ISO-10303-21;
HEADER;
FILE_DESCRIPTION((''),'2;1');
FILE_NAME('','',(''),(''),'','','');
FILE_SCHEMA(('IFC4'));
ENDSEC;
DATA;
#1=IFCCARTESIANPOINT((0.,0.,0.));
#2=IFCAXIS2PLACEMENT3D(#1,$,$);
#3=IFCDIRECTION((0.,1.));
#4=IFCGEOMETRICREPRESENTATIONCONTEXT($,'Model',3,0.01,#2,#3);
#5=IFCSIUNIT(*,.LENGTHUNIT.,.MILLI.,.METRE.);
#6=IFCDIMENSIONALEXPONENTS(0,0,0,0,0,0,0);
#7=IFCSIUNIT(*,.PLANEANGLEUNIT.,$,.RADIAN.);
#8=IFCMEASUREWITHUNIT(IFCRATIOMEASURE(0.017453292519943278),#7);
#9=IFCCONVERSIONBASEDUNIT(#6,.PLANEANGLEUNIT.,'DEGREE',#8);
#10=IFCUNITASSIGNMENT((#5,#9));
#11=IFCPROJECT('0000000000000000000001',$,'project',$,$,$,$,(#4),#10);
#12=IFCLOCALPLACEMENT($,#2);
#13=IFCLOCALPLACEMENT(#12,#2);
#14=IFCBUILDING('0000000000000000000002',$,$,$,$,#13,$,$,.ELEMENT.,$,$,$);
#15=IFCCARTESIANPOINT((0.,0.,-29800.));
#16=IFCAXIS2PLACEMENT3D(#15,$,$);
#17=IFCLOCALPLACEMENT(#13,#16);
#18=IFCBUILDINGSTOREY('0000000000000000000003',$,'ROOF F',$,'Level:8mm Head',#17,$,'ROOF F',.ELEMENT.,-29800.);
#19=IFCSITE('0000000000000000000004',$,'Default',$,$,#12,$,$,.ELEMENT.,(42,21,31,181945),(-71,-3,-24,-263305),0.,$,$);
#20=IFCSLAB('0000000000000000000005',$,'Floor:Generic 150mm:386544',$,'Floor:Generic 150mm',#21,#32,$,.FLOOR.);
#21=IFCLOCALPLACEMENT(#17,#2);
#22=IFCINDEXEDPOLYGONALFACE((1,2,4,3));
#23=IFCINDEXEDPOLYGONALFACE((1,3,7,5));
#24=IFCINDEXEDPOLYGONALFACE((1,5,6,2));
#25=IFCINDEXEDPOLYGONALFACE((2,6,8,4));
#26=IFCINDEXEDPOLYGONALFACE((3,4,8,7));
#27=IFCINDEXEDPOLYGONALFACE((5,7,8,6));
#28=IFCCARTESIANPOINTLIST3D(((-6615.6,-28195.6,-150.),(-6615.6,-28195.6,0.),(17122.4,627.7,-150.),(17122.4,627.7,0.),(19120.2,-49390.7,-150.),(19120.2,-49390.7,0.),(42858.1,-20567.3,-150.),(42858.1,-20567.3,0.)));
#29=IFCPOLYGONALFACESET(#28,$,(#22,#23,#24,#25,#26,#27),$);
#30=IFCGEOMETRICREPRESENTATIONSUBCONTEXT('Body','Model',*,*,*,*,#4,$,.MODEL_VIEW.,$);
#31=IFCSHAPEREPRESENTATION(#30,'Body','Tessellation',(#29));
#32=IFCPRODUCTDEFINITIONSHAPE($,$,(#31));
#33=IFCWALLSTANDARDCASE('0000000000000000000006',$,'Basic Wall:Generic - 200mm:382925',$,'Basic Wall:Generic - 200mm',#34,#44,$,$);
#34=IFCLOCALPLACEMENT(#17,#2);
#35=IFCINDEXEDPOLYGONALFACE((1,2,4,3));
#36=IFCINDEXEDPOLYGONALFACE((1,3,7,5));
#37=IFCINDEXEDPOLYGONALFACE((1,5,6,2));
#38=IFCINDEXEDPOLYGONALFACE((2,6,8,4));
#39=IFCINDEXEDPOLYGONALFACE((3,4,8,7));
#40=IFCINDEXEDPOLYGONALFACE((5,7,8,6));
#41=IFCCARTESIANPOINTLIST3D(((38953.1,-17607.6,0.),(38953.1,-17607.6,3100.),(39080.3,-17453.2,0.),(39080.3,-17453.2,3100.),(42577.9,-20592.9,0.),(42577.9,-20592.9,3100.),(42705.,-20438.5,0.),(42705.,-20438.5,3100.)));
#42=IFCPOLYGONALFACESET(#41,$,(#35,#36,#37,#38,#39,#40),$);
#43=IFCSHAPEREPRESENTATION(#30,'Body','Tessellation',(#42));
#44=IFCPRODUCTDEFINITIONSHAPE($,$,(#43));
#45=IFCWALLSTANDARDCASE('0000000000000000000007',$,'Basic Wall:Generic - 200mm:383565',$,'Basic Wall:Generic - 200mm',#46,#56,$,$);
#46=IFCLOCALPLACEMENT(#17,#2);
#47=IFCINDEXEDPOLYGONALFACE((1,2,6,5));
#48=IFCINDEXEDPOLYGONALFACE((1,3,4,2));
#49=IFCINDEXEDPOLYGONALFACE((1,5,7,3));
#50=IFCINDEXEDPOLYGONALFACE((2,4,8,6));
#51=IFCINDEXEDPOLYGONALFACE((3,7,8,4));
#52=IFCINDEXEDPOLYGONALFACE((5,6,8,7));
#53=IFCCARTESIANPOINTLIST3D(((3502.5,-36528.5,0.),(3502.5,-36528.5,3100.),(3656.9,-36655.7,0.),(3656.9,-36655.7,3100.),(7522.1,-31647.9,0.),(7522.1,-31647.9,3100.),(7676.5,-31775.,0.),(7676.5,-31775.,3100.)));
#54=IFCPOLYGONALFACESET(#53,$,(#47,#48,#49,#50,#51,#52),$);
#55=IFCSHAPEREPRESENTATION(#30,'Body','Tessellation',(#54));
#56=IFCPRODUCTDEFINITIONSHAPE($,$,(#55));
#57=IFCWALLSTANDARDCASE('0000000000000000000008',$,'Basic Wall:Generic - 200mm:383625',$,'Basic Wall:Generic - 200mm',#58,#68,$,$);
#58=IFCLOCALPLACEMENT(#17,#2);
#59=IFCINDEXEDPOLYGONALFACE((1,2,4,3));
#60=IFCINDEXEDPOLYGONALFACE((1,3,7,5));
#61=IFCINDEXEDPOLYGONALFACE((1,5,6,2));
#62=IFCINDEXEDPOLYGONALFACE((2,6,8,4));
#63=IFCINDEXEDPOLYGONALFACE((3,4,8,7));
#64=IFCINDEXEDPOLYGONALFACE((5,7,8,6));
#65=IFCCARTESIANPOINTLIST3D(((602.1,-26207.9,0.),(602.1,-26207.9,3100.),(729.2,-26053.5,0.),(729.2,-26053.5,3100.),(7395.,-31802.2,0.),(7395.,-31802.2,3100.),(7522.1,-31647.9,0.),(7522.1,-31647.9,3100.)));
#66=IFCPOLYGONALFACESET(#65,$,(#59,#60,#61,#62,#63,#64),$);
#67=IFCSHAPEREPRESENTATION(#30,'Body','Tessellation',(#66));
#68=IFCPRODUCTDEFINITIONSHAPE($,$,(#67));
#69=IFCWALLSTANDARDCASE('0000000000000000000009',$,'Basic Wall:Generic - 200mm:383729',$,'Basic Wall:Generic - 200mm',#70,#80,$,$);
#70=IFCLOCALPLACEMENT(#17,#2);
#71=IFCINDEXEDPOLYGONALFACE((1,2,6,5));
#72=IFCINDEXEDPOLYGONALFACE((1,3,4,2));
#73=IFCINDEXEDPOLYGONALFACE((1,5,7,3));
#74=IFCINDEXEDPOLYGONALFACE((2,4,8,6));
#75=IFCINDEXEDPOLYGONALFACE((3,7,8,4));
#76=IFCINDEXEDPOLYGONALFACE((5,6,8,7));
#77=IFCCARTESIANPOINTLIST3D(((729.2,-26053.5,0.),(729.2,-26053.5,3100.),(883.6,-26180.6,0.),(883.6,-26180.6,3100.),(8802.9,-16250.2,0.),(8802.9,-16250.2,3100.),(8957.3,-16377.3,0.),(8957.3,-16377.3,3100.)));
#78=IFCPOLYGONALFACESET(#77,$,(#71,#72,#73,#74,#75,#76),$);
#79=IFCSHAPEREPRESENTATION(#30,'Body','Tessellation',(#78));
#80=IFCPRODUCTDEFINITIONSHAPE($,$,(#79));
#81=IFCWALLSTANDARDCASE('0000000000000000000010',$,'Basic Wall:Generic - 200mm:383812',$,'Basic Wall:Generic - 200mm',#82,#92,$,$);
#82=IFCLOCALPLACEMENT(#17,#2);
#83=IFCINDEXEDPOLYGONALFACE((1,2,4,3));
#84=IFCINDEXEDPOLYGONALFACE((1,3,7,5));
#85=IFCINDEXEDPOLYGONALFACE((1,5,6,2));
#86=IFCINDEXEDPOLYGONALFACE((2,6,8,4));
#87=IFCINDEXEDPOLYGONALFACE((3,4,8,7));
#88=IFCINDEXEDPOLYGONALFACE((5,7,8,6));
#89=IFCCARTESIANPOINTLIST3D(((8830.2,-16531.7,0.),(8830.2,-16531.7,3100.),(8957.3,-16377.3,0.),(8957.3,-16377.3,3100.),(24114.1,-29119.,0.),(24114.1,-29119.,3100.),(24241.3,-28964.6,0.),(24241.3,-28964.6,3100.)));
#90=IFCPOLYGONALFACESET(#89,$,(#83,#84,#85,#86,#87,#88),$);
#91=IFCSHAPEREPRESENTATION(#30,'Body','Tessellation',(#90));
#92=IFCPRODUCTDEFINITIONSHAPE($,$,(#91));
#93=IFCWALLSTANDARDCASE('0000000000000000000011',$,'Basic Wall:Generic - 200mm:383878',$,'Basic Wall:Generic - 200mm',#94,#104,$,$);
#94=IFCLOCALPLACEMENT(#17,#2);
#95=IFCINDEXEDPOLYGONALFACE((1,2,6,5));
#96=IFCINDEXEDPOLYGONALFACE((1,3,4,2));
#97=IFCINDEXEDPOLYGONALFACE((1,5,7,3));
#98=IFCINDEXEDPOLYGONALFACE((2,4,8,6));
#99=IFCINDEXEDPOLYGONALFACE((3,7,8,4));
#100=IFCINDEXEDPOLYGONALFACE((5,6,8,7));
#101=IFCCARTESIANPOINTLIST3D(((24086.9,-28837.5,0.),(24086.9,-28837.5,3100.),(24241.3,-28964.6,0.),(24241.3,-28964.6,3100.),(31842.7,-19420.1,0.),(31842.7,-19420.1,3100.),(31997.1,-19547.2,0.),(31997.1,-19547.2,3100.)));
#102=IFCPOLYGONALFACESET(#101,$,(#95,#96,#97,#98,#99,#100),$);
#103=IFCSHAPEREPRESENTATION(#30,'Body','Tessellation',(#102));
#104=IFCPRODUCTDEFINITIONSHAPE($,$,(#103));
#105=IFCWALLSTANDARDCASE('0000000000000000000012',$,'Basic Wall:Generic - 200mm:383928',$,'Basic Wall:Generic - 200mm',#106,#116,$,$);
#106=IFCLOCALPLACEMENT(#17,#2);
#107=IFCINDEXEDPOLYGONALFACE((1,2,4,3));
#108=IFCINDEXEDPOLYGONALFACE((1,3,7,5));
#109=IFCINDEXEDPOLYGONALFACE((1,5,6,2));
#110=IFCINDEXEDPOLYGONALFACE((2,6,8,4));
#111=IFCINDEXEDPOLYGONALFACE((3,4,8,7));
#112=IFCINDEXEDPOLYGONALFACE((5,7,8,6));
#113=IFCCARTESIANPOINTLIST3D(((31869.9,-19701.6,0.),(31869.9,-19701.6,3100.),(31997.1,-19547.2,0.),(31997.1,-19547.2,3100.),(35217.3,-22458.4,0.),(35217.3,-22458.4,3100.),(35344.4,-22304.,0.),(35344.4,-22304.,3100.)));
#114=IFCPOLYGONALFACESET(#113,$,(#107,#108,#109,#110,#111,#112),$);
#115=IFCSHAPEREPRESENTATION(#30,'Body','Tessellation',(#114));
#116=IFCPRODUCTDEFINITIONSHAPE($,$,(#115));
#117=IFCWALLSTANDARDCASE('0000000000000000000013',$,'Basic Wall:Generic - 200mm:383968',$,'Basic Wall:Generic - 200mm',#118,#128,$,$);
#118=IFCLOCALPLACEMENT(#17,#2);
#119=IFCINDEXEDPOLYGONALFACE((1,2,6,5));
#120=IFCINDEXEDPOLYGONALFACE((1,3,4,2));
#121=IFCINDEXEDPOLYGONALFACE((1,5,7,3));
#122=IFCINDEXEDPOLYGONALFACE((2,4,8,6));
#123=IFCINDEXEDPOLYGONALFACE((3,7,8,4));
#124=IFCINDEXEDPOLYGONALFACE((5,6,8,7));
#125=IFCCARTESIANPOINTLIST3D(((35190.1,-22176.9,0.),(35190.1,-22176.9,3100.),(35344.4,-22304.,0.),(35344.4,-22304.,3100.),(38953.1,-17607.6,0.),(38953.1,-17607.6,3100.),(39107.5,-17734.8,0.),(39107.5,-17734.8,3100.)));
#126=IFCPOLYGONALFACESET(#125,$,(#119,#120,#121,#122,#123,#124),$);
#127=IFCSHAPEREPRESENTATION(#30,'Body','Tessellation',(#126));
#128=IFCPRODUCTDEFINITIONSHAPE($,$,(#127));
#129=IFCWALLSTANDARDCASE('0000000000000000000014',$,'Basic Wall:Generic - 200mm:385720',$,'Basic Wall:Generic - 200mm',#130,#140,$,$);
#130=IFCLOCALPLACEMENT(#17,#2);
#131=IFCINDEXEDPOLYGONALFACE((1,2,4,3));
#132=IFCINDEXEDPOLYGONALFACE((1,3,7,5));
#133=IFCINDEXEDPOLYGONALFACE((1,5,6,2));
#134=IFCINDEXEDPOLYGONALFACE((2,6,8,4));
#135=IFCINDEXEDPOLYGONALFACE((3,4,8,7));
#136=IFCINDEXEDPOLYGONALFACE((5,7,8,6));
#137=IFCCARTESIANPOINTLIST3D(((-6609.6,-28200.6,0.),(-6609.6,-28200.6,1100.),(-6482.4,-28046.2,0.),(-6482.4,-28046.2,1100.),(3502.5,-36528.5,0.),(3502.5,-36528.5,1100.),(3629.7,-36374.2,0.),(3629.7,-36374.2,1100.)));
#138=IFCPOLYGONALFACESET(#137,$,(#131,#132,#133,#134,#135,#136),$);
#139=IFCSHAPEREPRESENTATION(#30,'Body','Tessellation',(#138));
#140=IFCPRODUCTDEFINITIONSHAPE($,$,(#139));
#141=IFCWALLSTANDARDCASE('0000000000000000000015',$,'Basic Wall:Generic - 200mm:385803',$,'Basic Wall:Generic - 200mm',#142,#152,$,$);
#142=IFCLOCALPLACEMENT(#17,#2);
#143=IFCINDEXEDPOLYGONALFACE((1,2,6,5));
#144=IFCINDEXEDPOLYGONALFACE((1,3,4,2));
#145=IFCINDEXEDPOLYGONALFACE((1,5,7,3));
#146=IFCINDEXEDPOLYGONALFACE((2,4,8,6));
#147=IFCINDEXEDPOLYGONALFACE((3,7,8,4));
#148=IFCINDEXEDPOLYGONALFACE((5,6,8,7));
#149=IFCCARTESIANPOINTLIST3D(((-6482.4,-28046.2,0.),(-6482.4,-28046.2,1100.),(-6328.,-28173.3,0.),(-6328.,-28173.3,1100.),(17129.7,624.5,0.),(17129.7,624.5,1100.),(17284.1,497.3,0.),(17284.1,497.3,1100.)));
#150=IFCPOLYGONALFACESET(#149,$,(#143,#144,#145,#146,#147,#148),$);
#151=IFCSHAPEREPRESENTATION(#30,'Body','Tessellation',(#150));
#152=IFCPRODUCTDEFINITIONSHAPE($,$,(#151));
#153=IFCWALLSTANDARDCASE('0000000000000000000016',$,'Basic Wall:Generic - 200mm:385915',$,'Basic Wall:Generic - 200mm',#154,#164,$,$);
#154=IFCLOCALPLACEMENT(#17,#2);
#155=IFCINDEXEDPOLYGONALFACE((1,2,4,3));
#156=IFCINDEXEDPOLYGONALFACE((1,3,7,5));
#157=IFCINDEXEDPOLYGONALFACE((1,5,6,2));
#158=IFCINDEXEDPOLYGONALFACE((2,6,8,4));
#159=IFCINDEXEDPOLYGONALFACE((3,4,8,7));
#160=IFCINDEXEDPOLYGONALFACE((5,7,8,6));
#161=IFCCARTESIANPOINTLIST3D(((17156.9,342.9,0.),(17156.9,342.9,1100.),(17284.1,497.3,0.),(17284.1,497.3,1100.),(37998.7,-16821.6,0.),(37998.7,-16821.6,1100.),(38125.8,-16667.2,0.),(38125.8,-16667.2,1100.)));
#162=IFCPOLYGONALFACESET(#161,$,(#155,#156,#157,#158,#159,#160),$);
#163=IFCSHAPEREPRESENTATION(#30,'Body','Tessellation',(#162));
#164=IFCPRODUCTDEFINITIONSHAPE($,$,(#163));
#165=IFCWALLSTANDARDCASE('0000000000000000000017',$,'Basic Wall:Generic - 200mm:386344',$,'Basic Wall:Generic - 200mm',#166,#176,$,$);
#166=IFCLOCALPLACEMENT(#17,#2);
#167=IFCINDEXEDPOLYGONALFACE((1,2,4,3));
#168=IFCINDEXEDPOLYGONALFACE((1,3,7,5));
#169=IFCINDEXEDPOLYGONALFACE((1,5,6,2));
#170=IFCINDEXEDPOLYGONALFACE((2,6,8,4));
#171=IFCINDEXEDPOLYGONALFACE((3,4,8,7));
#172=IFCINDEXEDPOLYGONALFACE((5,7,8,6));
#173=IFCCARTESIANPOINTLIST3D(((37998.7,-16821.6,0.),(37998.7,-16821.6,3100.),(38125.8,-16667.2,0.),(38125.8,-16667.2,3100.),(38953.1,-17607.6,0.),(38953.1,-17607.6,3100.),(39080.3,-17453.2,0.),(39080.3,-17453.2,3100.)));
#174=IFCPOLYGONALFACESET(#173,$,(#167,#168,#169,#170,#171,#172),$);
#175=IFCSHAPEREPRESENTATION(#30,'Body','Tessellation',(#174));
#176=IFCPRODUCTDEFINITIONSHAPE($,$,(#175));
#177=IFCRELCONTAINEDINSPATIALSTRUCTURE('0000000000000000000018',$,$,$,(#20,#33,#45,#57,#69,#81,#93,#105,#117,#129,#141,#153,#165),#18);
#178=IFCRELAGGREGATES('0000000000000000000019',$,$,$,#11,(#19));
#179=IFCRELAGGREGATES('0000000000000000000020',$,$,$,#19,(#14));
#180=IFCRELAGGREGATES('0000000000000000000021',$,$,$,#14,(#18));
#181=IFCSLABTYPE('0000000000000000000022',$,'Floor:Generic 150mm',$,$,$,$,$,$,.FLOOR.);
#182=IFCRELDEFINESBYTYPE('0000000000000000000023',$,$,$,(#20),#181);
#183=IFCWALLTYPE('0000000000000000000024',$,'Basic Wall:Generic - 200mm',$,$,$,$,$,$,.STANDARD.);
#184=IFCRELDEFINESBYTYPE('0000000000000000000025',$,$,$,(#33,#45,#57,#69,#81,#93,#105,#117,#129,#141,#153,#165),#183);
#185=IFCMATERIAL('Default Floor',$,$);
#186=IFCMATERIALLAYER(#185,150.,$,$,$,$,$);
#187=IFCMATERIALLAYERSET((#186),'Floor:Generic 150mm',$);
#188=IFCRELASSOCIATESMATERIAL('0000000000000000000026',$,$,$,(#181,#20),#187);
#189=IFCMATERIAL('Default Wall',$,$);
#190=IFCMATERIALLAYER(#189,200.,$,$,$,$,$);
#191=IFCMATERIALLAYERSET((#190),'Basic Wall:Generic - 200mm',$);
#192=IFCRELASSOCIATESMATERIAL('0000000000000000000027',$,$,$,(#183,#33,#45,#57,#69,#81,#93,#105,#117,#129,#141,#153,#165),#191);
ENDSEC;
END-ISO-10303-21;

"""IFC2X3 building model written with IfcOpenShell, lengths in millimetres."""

from ifc_helpers import new_model, entity, si_unit, converted_unit, direction, frame, frame_2d, origin, place, context, subcontext, project, spatial, rectangle, extrude, material, layer, layer_set, layer_usage, type_object, element, save


model = new_model("IFC2X3")

# Units and contexts
model_context = context("Model", 3, precision=0.01, world=origin(), true_north=direction((0.0, 1.0)))
body_context = subcontext(model_context, "Body", "Model", "MODEL_VIEW")
ifc_project = project(units=[si_unit("LENGTHUNIT", "METRE", prefix="MILLI"), converted_unit("PLANEANGLEUNIT", "DEGREE", entity("IfcRatioMeasure", 0.017453292519943278), si_unit("PLANEANGLEUNIT", "RADIAN"), dimensions=[0, 0, 0, 0, 0, 0, 0])], contexts=[model_context])

# Site, building, storey
site_placement = place(None, origin())
site = spatial("IfcSite", under=ifc_project, at=site_placement, Name="Default", CompositionType="ELEMENT", RefLatitude=(42, 21, 31, 181945), RefLongitude=(-71, -3, -24, -263305), RefElevation=0.0)
building_placement = place(site_placement, origin())
building = spatial("IfcBuilding", under=site, at=building_placement, CompositionType="ELEMENT")
storey_placement = place(building_placement, frame((0.0, 0.0, -29800.0)))
storey = spatial("IfcBuildingStorey", under=building, at=storey_placement, Name="ROOF F", ObjectType="Level:8mm Head", LongName="ROOF F", CompositionType="ELEMENT", Elevation=-29800.0)

# Slab
ifc_material_1 = material(Name="Default Floor")
ifc_layer_1 = layer(ifc_material_1, 150.0)
ifc_layer_set_1 = layer_set([ifc_layer_1], Name="Floor:Generic 150mm")
ifc_layer_usage_1 = layer_usage(ifc_layer_set_1, "AXIS3", "POSITIVE", 0.0)
slab_type = type_object("IfcSlabType", Name="Floor:Generic 150mm", PredefinedType="FLOOR", material=ifc_layer_set_1)
slab_placement = place(storey_placement, origin())
element("IfcSlab", 1, at=slab_placement, inside=storey, type_object=slab_type, material=ifc_layer_usage_1, Name="Floor:Generic 150mm:386544", ObjectType="Floor:Generic 150mm", PredefinedType="FLOOR", context=body_context, shape_type="SweptSolid", body=[
    extrude(rectangle(XDim=33340.0, YDim=37340.0, at=frame_2d((0.0, 0.0), x_axis=(1.0, 0.0))), frame((18121.3, -24381.5, 0.0), z_axis=(0.0, 0.0, -1.0), x_axis=(0.771917, -0.635723, 0.0)), (0.0, 0.0, 1.0), 150.0),
])

# Shared definitions
ifc_material_2 = material(Name="Default Wall")
ifc_layer_2 = layer(ifc_material_2, 200.0)
ifc_layer_set_2 = layer_set([ifc_layer_2], Name="Basic Wall:Generic - 200mm")
ifc_layer_usage_2 = layer_usage(ifc_layer_set_2, "AXIS2", "NEGATIVE", 100.0)
wall_type = type_object("IfcWallType", Name="Basic Wall:Generic - 200mm", PredefinedType="STANDARD", material=ifc_layer_set_2)

# Walls
wall_1_placement = place(storey_placement, frame((42641.5, -20515.7, 0.0), z_axis=(0.0, 0.0, 1.0), x_axis=(-0.771917, 0.635723, 0.0)))
element("IfcWallStandardCase", 2, at=wall_1_placement, inside=storey, type_object=wall_type, material=ifc_layer_usage_2, Name="Basic Wall:Generic - 200mm:382925", ObjectType="Basic Wall:Generic - 200mm", context=body_context, shape_type="SweptSolid", body=[
    extrude(rectangle(XDim=4695.8, YDim=200.0, at=frame_2d((2347.9, 0.0), x_axis=(-1.0, 0.0))), origin(), (0.0, 0.0, 1.0), 3100.0),
])
wall_2_placement = place(storey_placement, frame((3579.7, -36592.1, 0.0), z_axis=(0.0, 0.0, 1.0), x_axis=(0.635723, 0.771917, 0.0)))
element("IfcWallStandardCase", 3, at=wall_2_placement, inside=storey, type_object=wall_type, material=ifc_layer_usage_2, Name="Basic Wall:Generic - 200mm:383565", ObjectType="Basic Wall:Generic - 200mm", context=body_context, shape_type="SweptSolid", body=[
    extrude(rectangle(XDim=6322.8, YDim=200.0, at=frame_2d((3161.4, 0.0), x_axis=(-1.0, 0.0))), origin(), (0.0, 0.0, 1.0), 3100.0),
])
wall_3_placement = place(storey_placement, frame((665.7, -26130.7, 0.0), z_axis=(0.0, 0.0, 1.0), x_axis=(0.771917, -0.635723, 0.0)))
element("IfcWallStandardCase", 4, at=wall_3_placement, inside=storey, type_object=wall_type, material=ifc_layer_usage_2, Name="Basic Wall:Generic - 200mm:383625", ObjectType="Basic Wall:Generic - 200mm", context=body_context, shape_type="SweptSolid", body=[
    extrude(rectangle(XDim=8800.0, YDim=200.0, at=frame_2d((4400.0, 0.0), x_axis=(-1.0, 0.0))), origin(), (0.0, 0.0, 1.0), 3100.0),
])
wall_4_placement = place(storey_placement, frame((806.4, -26117.1, 0.0), z_axis=(0.0, 0.0, 1.0), x_axis=(0.635723, 0.771917, 0.0)))
element("IfcWallStandardCase", 5, at=wall_4_placement, inside=storey, type_object=wall_type, material=ifc_layer_usage_2, Name="Basic Wall:Generic - 200mm:383729", ObjectType="Basic Wall:Generic - 200mm", context=body_context, shape_type="SweptSolid", body=[
    extrude(rectangle(XDim=12700.0, YDim=200.0, at=frame_2d((6350.0, 0.0), x_axis=(-1.0, 0.0))), origin(), (0.0, 0.0, 1.0), 3100.0),
])
wall_5_placement = place(storey_placement, frame((8893.7, -16454.5, 0.0), z_axis=(0.0, 0.0, 1.0), x_axis=(0.771917, -0.635723, 0.0)))
element("IfcWallStandardCase", 6, at=wall_5_placement, inside=storey, type_object=wall_type, material=ifc_layer_usage_2, Name="Basic Wall:Generic - 200mm:383812", ObjectType="Basic Wall:Generic - 200mm", context=body_context, shape_type="SweptSolid", body=[
    extrude(rectangle(XDim=19800.0, YDim=200.0, at=frame_2d((9900.0, 0.0), x_axis=(-1.0, 0.0))), origin(), (0.0, 0.0, 1.0), 3100.0),
])
wall_6_placement = place(storey_placement, frame((24164.1, -28901.0, 0.0), z_axis=(0.0, 0.0, 1.0), x_axis=(0.635723, 0.771917, 0.0)))
element("IfcWallStandardCase", 7, at=wall_6_placement, inside=storey, type_object=wall_type, material=ifc_layer_usage_2, Name="Basic Wall:Generic - 200mm:383878", ObjectType="Basic Wall:Generic - 200mm", context=body_context, shape_type="SweptSolid", body=[
    extrude(rectangle(XDim=12200.0, YDim=200.0, at=frame_2d((6100.0, 0.0), x_axis=(-1.0, 0.0))), origin(), (0.0, 0.0, 1.0), 3100.0),
])
wall_7_placement = place(storey_placement, frame((31933.5, -19624.4, 0.0), z_axis=(0.0, 0.0, 1.0), x_axis=(0.771917, -0.635723, 0.0)))
element("IfcWallStandardCase", 8, at=wall_7_placement, inside=storey, type_object=wall_type, material=ifc_layer_usage_2, Name="Basic Wall:Generic - 200mm:383928", ObjectType="Basic Wall:Generic - 200mm", context=body_context, shape_type="SweptSolid", body=[
    extrude(rectangle(XDim=4336.4, YDim=200.0, at=frame_2d((2168.2, 0.0), x_axis=(-1.0, 0.0))), origin(), (0.0, 0.0, 1.0), 3100.0),
])
wall_8_placement = place(storey_placement, frame((35267.2, -22240.4, 0.0), z_axis=(0.0, 0.0, 1.0), x_axis=(0.635723, 0.771917, 0.0)))
element("IfcWallStandardCase", 9, at=wall_8_placement, inside=storey, type_object=wall_type, material=ifc_layer_usage_2, Name="Basic Wall:Generic - 200mm:383968", ObjectType="Basic Wall:Generic - 200mm", context=body_context, shape_type="SweptSolid", body=[
    extrude(rectangle(XDim=5919.3, YDim=200.0, at=frame_2d((2959.7, 0.0), x_axis=(-1.0, 0.0))), origin(), (0.0, 0.0, 1.0), 3100.0),
])

# Walls
wall_9_placement = place(storey_placement, frame((3566.1, -36451.4, 0.0), z_axis=(0.0, 0.0, 1.0), x_axis=(-0.771917, 0.635723, 0.0)))
element("IfcWallStandardCase", 10, at=wall_9_placement, inside=storey, type_object=wall_type, material=ifc_layer_usage_2, Name="Basic Wall:Generic - 200mm:385720", ObjectType="Basic Wall:Generic - 200mm", context=body_context, shape_type="SweptSolid", body=[
    extrude(rectangle(XDim=13100.0, YDim=200.0, at=frame_2d((6550.0, 0.0), x_axis=(-1.0, 0.0))), origin(), (0.0, 0.0, 1.0), 1100.0),
])
wall_10_placement = place(storey_placement, frame((-6405.2, -28109.8, 0.0), z_axis=(0.0, 0.0, 1.0), x_axis=(0.635723, 0.771917, 0.0)))
element("IfcWallStandardCase", 11, at=wall_10_placement, inside=storey, type_object=wall_type, material=ifc_layer_usage_2, Name="Basic Wall:Generic - 200mm:385803", ObjectType="Basic Wall:Generic - 200mm", context=body_context, shape_type="SweptSolid", body=[
    extrude(rectangle(XDim=37142.1, YDim=200.0, at=frame_2d((18571.1, 0.0), x_axis=(-1.0, 0.0))), origin(), (0.0, 0.0, 1.0), 1100.0),
])
wall_11_placement = place(storey_placement, frame((17220.5, 420.1, 0.0), z_axis=(0.0, 0.0, 1.0), x_axis=(0.771917, -0.635723, 0.0)))
element("IfcWallStandardCase", 12, at=wall_11_placement, inside=storey, type_object=wall_type, material=ifc_layer_usage_2, Name="Basic Wall:Generic - 200mm:385915", ObjectType="Basic Wall:Generic - 200mm", context=body_context, shape_type="SweptSolid", body=[
    extrude(rectangle(XDim=27000.0, YDim=200.0, at=frame_2d((13500.0, 0.0), x_axis=(-1.0, 0.0))), origin(), (0.0, 0.0, 1.0), 1100.0),
])
wall_12_placement = place(storey_placement, frame((38062.3, -16744.4, 0.0), z_axis=(0.0, 0.0, 1.0), x_axis=(0.771917, -0.635723, 0.0)))
element("IfcWallStandardCase", 13, at=wall_12_placement, inside=storey, type_object=wall_type, material=ifc_layer_usage_2, Name="Basic Wall:Generic - 200mm:386344", ObjectType="Basic Wall:Generic - 200mm", context=body_context, shape_type="SweptSolid", body=[
    extrude(rectangle(XDim=1236.4, YDim=200.0, at=frame_2d((618.2, 0.0), x_axis=(-1.0, 0.0))), origin(), (0.0, 0.0, 1.0), 3100.0),
])

save(model, "model.ifc")
